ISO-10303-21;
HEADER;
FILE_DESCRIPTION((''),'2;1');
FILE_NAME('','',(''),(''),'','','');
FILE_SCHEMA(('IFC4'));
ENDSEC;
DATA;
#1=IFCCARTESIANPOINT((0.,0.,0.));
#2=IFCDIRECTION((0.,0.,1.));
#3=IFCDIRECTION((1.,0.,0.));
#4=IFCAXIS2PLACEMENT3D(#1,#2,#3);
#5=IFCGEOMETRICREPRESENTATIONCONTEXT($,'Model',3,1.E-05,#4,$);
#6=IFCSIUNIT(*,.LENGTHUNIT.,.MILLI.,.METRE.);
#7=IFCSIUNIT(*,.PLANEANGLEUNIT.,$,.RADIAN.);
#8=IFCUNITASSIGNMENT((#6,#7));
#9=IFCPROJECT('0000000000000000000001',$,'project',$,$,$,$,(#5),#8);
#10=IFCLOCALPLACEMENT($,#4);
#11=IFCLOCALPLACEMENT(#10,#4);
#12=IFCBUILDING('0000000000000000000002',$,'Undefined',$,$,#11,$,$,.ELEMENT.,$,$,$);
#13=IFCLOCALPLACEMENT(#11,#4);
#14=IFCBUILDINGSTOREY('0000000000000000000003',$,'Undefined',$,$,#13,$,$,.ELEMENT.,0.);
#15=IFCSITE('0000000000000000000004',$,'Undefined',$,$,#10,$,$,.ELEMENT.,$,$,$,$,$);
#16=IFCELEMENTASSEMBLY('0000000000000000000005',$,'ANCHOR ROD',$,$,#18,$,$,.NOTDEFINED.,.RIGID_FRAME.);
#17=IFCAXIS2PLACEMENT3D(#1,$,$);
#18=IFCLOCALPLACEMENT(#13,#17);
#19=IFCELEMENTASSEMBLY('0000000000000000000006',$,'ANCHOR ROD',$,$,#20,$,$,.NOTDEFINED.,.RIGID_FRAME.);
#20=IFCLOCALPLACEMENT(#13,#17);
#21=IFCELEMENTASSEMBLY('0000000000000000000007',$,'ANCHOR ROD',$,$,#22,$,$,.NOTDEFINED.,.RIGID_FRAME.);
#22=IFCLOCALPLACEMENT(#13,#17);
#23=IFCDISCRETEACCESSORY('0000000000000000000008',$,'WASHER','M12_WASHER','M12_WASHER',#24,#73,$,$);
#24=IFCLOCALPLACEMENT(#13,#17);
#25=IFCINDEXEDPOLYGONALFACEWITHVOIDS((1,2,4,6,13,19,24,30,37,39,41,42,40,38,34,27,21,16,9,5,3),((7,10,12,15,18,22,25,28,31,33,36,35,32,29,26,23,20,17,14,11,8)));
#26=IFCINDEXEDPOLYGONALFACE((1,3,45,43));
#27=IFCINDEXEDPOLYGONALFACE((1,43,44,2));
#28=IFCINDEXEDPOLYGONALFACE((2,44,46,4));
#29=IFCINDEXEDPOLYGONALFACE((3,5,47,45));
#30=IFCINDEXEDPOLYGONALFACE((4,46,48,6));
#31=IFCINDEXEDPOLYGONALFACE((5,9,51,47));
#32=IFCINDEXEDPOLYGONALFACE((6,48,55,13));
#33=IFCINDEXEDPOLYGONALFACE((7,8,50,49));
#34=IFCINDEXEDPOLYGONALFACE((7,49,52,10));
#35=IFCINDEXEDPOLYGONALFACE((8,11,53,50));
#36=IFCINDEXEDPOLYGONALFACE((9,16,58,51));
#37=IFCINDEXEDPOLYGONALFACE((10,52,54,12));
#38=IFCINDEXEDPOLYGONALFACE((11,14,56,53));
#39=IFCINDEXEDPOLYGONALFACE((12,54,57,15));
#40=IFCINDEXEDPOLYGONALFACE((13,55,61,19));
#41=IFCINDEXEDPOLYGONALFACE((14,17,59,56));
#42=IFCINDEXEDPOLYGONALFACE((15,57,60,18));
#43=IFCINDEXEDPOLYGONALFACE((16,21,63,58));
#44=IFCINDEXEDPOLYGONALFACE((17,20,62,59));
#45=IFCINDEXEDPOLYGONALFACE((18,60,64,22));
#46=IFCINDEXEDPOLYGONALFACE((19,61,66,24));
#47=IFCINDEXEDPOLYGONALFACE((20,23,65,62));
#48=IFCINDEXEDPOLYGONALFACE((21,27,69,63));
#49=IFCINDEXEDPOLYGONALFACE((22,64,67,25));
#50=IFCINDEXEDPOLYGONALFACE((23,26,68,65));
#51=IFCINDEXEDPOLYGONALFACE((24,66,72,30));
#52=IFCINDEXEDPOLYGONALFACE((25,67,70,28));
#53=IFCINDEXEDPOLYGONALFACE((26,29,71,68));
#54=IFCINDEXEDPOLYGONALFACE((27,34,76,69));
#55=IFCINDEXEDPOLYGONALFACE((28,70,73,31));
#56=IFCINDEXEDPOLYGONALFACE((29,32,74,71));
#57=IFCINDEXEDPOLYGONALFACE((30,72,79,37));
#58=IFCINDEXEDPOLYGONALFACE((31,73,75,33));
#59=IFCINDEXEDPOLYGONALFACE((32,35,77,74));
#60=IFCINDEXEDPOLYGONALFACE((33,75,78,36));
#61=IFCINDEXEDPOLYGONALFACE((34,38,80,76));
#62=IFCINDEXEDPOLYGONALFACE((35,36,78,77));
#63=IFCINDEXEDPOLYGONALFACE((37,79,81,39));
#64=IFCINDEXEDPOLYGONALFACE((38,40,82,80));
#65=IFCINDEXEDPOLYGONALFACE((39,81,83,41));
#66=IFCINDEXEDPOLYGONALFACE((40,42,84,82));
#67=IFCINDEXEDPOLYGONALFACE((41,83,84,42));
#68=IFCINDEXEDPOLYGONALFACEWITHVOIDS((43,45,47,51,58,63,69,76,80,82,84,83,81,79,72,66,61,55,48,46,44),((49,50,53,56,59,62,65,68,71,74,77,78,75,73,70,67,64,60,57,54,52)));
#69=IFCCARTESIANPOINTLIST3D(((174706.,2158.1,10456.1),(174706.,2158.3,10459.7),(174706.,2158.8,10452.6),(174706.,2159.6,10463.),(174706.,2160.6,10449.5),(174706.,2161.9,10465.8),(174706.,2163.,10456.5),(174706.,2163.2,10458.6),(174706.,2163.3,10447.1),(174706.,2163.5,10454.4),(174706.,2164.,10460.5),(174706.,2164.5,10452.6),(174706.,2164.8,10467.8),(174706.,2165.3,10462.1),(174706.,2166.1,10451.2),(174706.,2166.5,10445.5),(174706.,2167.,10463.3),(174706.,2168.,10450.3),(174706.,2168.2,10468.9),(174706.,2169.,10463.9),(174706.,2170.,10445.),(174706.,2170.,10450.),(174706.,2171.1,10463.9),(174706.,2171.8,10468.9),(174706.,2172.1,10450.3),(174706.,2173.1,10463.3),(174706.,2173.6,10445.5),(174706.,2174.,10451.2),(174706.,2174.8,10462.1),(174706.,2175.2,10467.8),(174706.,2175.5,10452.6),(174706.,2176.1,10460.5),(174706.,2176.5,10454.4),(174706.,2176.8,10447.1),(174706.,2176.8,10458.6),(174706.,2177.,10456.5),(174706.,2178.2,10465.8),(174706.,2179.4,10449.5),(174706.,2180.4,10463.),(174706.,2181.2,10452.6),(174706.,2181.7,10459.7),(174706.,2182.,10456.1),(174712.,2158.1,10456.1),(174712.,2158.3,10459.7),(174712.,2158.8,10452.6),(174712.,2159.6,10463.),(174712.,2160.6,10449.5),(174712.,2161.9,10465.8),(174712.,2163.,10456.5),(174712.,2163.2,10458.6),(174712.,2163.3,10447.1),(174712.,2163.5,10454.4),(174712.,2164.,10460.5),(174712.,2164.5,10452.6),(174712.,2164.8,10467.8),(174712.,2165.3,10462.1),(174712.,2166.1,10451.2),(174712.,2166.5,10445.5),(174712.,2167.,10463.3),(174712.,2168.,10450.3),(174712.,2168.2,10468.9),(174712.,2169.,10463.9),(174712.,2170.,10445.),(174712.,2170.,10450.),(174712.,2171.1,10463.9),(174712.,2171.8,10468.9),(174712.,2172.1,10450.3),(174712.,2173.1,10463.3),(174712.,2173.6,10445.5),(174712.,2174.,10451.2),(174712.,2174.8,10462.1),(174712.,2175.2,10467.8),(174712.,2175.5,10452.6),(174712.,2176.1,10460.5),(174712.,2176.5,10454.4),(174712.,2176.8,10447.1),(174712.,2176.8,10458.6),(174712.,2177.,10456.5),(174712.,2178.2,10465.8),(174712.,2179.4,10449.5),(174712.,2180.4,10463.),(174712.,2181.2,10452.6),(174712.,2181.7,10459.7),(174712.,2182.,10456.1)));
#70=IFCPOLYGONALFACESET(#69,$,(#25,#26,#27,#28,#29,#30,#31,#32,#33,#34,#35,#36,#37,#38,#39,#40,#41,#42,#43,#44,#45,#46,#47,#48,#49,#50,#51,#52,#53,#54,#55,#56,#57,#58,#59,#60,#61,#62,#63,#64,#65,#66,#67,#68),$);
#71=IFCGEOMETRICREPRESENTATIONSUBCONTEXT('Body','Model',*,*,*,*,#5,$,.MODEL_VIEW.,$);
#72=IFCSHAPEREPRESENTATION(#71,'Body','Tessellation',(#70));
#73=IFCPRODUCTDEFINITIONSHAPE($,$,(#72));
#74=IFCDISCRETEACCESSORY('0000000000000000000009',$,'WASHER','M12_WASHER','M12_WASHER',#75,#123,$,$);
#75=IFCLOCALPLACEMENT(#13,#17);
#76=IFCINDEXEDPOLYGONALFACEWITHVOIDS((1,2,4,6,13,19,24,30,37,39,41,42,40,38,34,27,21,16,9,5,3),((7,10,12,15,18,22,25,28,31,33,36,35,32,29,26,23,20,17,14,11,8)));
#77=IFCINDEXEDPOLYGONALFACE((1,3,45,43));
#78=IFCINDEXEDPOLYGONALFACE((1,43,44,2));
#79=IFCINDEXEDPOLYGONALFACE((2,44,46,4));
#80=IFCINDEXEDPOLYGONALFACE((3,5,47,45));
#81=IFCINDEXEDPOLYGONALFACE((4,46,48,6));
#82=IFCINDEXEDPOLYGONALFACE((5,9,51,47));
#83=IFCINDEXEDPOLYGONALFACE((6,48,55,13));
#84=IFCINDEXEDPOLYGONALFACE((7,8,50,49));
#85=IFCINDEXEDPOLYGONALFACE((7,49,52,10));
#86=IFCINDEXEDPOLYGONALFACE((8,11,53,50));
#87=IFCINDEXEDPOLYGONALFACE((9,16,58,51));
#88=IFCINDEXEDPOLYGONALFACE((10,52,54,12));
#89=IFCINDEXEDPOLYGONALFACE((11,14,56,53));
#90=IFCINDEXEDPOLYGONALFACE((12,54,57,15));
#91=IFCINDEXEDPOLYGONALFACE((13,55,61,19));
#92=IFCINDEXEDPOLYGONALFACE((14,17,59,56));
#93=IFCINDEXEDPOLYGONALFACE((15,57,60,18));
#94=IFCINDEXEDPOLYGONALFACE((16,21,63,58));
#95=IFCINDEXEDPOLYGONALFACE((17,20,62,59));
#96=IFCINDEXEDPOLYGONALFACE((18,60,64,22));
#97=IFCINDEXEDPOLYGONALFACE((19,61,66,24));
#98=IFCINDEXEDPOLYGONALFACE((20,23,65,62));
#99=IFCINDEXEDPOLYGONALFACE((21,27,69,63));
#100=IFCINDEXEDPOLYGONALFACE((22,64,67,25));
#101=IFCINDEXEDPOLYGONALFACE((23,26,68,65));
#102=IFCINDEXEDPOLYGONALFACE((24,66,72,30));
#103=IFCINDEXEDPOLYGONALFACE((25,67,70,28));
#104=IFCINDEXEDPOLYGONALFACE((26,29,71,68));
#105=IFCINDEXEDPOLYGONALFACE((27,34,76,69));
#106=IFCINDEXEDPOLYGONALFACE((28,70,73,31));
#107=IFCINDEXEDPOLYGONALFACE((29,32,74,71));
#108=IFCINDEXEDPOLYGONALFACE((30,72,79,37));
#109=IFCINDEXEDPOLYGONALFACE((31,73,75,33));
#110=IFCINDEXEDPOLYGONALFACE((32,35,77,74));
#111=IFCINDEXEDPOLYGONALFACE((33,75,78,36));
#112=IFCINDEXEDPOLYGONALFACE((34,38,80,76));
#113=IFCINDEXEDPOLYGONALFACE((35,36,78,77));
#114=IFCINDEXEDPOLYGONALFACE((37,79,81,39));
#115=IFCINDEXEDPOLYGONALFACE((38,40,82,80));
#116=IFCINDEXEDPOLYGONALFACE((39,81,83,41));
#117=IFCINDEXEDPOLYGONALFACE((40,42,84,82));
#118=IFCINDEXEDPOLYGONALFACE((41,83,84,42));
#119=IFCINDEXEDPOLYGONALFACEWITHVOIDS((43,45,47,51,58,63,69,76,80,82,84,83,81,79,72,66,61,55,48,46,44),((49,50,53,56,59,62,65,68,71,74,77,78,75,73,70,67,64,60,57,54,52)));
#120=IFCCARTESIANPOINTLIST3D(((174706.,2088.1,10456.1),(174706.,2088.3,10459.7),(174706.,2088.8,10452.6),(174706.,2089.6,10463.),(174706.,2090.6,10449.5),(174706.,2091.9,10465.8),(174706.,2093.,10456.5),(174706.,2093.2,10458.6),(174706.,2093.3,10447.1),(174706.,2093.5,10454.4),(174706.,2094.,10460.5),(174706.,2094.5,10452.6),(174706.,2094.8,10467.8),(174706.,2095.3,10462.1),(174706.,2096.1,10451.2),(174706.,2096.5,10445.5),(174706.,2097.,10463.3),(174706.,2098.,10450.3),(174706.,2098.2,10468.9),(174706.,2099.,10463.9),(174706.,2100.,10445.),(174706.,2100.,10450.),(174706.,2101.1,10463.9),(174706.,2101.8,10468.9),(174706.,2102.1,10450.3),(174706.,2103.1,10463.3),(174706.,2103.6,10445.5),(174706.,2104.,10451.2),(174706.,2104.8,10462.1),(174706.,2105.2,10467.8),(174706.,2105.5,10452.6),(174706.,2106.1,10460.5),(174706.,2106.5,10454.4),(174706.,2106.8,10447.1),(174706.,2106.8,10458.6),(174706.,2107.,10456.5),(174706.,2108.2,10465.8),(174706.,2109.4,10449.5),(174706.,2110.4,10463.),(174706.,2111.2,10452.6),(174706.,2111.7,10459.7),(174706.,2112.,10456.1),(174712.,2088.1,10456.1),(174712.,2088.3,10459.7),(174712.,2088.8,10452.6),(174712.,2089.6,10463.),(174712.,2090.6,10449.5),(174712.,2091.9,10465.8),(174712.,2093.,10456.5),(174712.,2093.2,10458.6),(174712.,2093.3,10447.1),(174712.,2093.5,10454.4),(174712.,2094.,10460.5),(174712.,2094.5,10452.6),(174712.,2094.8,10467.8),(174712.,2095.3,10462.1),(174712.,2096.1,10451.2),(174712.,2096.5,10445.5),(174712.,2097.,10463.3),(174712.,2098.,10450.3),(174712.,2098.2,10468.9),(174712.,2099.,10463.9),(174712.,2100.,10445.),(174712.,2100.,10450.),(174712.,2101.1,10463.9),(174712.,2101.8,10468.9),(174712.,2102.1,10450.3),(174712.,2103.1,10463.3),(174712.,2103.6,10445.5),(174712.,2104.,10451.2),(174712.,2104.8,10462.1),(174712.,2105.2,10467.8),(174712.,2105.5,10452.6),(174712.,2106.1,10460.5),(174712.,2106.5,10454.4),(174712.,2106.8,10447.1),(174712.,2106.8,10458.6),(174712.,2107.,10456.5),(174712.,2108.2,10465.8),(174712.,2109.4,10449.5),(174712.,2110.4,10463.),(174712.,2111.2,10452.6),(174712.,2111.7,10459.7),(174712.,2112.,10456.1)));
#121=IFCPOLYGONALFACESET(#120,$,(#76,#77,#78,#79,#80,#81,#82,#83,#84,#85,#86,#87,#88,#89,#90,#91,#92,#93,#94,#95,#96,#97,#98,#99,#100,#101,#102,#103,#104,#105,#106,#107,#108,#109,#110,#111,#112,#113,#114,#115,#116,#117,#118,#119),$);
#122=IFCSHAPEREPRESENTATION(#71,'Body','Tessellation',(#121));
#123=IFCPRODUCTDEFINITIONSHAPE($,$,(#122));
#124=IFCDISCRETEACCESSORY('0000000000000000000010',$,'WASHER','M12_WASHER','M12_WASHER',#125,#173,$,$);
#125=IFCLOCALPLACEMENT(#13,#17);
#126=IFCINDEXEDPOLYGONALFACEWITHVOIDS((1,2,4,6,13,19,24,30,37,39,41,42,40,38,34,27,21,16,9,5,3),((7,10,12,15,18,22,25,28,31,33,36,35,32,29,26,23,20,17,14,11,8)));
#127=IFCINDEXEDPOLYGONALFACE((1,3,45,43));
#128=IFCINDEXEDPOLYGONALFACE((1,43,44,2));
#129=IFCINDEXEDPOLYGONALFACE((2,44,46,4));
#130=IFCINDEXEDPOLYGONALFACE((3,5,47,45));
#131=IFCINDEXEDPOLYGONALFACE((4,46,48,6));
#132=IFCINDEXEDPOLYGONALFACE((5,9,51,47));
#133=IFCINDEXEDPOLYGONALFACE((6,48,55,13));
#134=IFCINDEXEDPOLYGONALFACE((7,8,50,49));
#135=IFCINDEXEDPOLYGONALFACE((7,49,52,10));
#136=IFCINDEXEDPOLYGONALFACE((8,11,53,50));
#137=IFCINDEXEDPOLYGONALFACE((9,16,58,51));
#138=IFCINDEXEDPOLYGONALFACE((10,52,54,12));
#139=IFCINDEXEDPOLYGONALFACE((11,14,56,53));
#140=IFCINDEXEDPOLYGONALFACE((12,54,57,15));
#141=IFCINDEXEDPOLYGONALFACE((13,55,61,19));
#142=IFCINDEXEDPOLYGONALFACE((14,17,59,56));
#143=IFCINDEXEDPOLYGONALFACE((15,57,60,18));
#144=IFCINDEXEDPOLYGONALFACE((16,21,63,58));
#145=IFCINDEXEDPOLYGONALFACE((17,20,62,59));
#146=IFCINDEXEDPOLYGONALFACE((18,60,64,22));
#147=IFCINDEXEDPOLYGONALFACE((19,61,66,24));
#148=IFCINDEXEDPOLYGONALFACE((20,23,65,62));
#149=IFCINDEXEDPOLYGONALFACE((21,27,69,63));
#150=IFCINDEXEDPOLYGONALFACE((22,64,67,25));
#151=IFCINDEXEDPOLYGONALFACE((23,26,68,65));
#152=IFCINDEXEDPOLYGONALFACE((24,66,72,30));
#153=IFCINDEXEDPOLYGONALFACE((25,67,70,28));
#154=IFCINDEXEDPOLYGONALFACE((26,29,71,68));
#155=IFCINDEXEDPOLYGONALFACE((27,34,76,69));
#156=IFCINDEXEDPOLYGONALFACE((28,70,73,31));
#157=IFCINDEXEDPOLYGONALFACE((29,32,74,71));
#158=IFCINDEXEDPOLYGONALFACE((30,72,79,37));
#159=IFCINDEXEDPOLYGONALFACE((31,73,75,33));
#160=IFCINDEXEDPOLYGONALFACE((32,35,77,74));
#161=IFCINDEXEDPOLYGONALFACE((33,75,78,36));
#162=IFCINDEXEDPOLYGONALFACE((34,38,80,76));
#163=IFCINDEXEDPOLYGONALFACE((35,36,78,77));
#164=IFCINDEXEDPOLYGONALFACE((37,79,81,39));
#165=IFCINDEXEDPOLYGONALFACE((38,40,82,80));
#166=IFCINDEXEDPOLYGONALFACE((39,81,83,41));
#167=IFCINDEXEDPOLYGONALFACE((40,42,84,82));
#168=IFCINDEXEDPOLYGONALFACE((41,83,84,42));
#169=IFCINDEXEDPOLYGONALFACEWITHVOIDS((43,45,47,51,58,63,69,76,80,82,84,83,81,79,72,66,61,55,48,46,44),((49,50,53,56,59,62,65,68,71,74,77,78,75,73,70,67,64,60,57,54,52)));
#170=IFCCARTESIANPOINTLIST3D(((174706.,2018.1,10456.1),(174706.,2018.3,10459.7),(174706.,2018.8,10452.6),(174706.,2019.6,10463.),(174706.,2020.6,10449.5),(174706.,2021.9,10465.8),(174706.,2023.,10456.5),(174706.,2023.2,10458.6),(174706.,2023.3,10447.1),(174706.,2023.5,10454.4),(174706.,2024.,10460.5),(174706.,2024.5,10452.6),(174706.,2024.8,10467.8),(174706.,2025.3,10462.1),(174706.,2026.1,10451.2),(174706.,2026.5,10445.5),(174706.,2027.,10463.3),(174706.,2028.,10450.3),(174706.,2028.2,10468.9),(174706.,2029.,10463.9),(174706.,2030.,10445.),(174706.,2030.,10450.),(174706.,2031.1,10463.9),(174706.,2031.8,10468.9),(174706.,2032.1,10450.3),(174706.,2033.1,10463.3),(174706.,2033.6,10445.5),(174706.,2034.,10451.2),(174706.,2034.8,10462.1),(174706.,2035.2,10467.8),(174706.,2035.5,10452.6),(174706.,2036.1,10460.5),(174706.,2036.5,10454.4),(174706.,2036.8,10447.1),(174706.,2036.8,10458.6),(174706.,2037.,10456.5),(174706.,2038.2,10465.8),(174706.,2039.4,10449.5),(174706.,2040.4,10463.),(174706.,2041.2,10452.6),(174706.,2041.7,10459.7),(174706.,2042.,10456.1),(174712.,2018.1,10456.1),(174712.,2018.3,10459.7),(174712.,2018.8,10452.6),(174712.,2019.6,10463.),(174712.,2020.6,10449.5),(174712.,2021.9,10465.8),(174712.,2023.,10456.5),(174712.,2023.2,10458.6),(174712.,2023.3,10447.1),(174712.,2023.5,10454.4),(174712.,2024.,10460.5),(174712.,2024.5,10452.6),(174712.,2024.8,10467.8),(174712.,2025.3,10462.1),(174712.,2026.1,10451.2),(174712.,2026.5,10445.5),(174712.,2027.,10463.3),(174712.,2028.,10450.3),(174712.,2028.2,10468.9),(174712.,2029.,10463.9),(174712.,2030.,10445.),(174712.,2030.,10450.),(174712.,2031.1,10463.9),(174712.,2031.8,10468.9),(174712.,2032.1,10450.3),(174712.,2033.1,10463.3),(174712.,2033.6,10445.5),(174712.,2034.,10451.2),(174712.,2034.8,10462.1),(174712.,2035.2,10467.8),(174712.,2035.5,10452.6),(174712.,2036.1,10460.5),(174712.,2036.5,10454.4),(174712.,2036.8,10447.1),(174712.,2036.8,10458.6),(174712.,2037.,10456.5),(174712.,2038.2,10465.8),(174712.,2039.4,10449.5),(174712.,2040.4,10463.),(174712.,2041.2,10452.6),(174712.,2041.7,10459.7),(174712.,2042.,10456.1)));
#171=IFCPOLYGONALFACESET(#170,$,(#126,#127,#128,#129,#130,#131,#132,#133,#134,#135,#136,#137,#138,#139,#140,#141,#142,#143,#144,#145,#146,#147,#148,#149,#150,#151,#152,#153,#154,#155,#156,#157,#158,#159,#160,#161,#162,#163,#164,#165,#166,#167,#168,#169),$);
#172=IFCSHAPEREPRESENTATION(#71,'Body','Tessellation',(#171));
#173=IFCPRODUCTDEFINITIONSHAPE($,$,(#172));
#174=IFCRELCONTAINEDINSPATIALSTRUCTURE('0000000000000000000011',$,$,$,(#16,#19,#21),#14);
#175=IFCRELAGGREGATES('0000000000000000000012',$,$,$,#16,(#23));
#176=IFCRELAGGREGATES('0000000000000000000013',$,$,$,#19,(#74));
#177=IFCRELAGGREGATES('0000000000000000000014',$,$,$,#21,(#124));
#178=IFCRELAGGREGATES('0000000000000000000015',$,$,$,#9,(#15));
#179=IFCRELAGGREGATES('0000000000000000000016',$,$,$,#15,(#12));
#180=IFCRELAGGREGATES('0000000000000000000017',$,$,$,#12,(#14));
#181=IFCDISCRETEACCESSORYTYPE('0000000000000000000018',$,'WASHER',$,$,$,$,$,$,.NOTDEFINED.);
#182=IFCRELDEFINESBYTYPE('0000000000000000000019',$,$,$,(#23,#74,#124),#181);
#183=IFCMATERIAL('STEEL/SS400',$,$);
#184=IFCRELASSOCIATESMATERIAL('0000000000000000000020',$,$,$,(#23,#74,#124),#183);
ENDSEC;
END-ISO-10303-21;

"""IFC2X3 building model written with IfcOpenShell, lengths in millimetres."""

from ifc_helpers import new_model, si_unit, frame, origin_with_axes, origin_2d_with_axis, place, context, subcontext, project, spatial, hollow_circle, extrude, material, type_object, element, aggregate, save


model = new_model("IFC2X3")

# Units and contexts
model_context = context("Model", 3, precision=1e-05, world=origin_with_axes())
body_context = subcontext(model_context, "Body", "Model", "MODEL_VIEW")
ifc_project = project(units=[si_unit("LENGTHUNIT", "METRE", prefix="MILLI"), si_unit("PLANEANGLEUNIT", "RADIAN")], contexts=[model_context])

# Site, building, storey
site_placement = place(None, origin_with_axes())
site = spatial("IfcSite", under=ifc_project, at=site_placement, Name="Undefined", CompositionType="ELEMENT")
building_placement = place(site_placement, origin_with_axes())
building = spatial("IfcBuilding", under=site, at=building_placement, Name="Undefined", CompositionType="ELEMENT")
storey_placement = place(building_placement, origin_with_axes())
storey = spatial("IfcBuildingStorey", under=building, at=storey_placement, Name="Undefined", CompositionType="ELEMENT", Elevation=0.0)

# Shared definitions
ifc_material_1 = material(Name="STEEL/SS400")

# Element assemblies
assembly_1_placement = place(storey_placement, origin_with_axes())
assembly_1 = element("IfcElementAssembly", 1, at=assembly_1_placement, inside=storey, Name="ANCHOR ROD", AssemblyPlace="NOTDEFINED", PredefinedType="RIGID_FRAME")
assembly_2_placement = place(storey_placement, origin_with_axes())
assembly_2 = element("IfcElementAssembly", 2, at=assembly_2_placement, inside=storey, Name="ANCHOR ROD", AssemblyPlace="NOTDEFINED", PredefinedType="RIGID_FRAME")
assembly_3_placement = place(storey_placement, origin_with_axes())
assembly_3 = element("IfcElementAssembly", 3, at=assembly_3_placement, inside=storey, Name="ANCHOR ROD", AssemblyPlace="NOTDEFINED", PredefinedType="RIGID_FRAME")
discrete_accessory_type_1 = type_object("IfcDiscreteAccessoryType", Name="WASHER")

# Discrete accessories
discrete_accessory_1_placement = place(assembly_1_placement, frame((174712.0, 2170.0, 10457.0), z_axis=(0.0, 1.0, 0.0), x_axis=(-1.0, 0.0, 0.0)))
discrete_accessory_1 = element("IfcDiscreteAccessory", 4, at=discrete_accessory_1_placement, type_object=discrete_accessory_type_1, material=ifc_material_1, Name="WASHER", Description="M12_WASHER", ObjectType="M12_WASHER", context=body_context, shape_type="SweptSolid", body=[
    extrude(hollow_circle(Radius=12.0, WallThickness=5.0, at=origin_2d_with_axis()), frame((6.0, 0.0, 0.0), z_axis=(-1.0, 0.0, 0.0), x_axis=(0.0, -1.0, 0.0)), (0.0, 0.0, 1.0), 6.0),
])
aggregate(assembly_1, [discrete_accessory_1])
discrete_accessory_2_placement = place(assembly_2_placement, frame((174712.0, 2100.0, 10457.0), z_axis=(0.0, 1.0, 0.0), x_axis=(-1.0, 0.0, 0.0)))
discrete_accessory_2 = element("IfcDiscreteAccessory", 5, at=discrete_accessory_2_placement, type_object=discrete_accessory_type_1, material=ifc_material_1, Name="WASHER", Description="M12_WASHER", ObjectType="M12_WASHER", context=body_context, shape_type="SweptSolid", body=[
    extrude(hollow_circle(Radius=12.0, WallThickness=5.0, at=origin_2d_with_axis()), frame((6.0, 0.0, 0.0), z_axis=(-1.0, 0.0, 0.0), x_axis=(0.0, -1.0, 0.0)), (0.0, 0.0, 1.0), 6.0),
])
aggregate(assembly_2, [discrete_accessory_2])
discrete_accessory_3_placement = place(assembly_3_placement, frame((174712.0, 2030.0, 10457.0), z_axis=(0.0, 1.0, 0.0), x_axis=(-1.0, 0.0, 0.0)))
discrete_accessory_3 = element("IfcDiscreteAccessory", 6, at=discrete_accessory_3_placement, type_object=discrete_accessory_type_1, material=ifc_material_1, Name="WASHER", Description="M12_WASHER", ObjectType="M12_WASHER", context=body_context, shape_type="SweptSolid", body=[
    extrude(hollow_circle(Radius=12.0, WallThickness=5.0, at=origin_2d_with_axis()), frame((6.0, 0.0, 0.0), z_axis=(-1.0, 0.0, 0.0), x_axis=(0.0, -1.0, 0.0)), (0.0, 0.0, 1.0), 6.0),
])
aggregate(assembly_3, [discrete_accessory_3])

save(model, "model.ifc")
